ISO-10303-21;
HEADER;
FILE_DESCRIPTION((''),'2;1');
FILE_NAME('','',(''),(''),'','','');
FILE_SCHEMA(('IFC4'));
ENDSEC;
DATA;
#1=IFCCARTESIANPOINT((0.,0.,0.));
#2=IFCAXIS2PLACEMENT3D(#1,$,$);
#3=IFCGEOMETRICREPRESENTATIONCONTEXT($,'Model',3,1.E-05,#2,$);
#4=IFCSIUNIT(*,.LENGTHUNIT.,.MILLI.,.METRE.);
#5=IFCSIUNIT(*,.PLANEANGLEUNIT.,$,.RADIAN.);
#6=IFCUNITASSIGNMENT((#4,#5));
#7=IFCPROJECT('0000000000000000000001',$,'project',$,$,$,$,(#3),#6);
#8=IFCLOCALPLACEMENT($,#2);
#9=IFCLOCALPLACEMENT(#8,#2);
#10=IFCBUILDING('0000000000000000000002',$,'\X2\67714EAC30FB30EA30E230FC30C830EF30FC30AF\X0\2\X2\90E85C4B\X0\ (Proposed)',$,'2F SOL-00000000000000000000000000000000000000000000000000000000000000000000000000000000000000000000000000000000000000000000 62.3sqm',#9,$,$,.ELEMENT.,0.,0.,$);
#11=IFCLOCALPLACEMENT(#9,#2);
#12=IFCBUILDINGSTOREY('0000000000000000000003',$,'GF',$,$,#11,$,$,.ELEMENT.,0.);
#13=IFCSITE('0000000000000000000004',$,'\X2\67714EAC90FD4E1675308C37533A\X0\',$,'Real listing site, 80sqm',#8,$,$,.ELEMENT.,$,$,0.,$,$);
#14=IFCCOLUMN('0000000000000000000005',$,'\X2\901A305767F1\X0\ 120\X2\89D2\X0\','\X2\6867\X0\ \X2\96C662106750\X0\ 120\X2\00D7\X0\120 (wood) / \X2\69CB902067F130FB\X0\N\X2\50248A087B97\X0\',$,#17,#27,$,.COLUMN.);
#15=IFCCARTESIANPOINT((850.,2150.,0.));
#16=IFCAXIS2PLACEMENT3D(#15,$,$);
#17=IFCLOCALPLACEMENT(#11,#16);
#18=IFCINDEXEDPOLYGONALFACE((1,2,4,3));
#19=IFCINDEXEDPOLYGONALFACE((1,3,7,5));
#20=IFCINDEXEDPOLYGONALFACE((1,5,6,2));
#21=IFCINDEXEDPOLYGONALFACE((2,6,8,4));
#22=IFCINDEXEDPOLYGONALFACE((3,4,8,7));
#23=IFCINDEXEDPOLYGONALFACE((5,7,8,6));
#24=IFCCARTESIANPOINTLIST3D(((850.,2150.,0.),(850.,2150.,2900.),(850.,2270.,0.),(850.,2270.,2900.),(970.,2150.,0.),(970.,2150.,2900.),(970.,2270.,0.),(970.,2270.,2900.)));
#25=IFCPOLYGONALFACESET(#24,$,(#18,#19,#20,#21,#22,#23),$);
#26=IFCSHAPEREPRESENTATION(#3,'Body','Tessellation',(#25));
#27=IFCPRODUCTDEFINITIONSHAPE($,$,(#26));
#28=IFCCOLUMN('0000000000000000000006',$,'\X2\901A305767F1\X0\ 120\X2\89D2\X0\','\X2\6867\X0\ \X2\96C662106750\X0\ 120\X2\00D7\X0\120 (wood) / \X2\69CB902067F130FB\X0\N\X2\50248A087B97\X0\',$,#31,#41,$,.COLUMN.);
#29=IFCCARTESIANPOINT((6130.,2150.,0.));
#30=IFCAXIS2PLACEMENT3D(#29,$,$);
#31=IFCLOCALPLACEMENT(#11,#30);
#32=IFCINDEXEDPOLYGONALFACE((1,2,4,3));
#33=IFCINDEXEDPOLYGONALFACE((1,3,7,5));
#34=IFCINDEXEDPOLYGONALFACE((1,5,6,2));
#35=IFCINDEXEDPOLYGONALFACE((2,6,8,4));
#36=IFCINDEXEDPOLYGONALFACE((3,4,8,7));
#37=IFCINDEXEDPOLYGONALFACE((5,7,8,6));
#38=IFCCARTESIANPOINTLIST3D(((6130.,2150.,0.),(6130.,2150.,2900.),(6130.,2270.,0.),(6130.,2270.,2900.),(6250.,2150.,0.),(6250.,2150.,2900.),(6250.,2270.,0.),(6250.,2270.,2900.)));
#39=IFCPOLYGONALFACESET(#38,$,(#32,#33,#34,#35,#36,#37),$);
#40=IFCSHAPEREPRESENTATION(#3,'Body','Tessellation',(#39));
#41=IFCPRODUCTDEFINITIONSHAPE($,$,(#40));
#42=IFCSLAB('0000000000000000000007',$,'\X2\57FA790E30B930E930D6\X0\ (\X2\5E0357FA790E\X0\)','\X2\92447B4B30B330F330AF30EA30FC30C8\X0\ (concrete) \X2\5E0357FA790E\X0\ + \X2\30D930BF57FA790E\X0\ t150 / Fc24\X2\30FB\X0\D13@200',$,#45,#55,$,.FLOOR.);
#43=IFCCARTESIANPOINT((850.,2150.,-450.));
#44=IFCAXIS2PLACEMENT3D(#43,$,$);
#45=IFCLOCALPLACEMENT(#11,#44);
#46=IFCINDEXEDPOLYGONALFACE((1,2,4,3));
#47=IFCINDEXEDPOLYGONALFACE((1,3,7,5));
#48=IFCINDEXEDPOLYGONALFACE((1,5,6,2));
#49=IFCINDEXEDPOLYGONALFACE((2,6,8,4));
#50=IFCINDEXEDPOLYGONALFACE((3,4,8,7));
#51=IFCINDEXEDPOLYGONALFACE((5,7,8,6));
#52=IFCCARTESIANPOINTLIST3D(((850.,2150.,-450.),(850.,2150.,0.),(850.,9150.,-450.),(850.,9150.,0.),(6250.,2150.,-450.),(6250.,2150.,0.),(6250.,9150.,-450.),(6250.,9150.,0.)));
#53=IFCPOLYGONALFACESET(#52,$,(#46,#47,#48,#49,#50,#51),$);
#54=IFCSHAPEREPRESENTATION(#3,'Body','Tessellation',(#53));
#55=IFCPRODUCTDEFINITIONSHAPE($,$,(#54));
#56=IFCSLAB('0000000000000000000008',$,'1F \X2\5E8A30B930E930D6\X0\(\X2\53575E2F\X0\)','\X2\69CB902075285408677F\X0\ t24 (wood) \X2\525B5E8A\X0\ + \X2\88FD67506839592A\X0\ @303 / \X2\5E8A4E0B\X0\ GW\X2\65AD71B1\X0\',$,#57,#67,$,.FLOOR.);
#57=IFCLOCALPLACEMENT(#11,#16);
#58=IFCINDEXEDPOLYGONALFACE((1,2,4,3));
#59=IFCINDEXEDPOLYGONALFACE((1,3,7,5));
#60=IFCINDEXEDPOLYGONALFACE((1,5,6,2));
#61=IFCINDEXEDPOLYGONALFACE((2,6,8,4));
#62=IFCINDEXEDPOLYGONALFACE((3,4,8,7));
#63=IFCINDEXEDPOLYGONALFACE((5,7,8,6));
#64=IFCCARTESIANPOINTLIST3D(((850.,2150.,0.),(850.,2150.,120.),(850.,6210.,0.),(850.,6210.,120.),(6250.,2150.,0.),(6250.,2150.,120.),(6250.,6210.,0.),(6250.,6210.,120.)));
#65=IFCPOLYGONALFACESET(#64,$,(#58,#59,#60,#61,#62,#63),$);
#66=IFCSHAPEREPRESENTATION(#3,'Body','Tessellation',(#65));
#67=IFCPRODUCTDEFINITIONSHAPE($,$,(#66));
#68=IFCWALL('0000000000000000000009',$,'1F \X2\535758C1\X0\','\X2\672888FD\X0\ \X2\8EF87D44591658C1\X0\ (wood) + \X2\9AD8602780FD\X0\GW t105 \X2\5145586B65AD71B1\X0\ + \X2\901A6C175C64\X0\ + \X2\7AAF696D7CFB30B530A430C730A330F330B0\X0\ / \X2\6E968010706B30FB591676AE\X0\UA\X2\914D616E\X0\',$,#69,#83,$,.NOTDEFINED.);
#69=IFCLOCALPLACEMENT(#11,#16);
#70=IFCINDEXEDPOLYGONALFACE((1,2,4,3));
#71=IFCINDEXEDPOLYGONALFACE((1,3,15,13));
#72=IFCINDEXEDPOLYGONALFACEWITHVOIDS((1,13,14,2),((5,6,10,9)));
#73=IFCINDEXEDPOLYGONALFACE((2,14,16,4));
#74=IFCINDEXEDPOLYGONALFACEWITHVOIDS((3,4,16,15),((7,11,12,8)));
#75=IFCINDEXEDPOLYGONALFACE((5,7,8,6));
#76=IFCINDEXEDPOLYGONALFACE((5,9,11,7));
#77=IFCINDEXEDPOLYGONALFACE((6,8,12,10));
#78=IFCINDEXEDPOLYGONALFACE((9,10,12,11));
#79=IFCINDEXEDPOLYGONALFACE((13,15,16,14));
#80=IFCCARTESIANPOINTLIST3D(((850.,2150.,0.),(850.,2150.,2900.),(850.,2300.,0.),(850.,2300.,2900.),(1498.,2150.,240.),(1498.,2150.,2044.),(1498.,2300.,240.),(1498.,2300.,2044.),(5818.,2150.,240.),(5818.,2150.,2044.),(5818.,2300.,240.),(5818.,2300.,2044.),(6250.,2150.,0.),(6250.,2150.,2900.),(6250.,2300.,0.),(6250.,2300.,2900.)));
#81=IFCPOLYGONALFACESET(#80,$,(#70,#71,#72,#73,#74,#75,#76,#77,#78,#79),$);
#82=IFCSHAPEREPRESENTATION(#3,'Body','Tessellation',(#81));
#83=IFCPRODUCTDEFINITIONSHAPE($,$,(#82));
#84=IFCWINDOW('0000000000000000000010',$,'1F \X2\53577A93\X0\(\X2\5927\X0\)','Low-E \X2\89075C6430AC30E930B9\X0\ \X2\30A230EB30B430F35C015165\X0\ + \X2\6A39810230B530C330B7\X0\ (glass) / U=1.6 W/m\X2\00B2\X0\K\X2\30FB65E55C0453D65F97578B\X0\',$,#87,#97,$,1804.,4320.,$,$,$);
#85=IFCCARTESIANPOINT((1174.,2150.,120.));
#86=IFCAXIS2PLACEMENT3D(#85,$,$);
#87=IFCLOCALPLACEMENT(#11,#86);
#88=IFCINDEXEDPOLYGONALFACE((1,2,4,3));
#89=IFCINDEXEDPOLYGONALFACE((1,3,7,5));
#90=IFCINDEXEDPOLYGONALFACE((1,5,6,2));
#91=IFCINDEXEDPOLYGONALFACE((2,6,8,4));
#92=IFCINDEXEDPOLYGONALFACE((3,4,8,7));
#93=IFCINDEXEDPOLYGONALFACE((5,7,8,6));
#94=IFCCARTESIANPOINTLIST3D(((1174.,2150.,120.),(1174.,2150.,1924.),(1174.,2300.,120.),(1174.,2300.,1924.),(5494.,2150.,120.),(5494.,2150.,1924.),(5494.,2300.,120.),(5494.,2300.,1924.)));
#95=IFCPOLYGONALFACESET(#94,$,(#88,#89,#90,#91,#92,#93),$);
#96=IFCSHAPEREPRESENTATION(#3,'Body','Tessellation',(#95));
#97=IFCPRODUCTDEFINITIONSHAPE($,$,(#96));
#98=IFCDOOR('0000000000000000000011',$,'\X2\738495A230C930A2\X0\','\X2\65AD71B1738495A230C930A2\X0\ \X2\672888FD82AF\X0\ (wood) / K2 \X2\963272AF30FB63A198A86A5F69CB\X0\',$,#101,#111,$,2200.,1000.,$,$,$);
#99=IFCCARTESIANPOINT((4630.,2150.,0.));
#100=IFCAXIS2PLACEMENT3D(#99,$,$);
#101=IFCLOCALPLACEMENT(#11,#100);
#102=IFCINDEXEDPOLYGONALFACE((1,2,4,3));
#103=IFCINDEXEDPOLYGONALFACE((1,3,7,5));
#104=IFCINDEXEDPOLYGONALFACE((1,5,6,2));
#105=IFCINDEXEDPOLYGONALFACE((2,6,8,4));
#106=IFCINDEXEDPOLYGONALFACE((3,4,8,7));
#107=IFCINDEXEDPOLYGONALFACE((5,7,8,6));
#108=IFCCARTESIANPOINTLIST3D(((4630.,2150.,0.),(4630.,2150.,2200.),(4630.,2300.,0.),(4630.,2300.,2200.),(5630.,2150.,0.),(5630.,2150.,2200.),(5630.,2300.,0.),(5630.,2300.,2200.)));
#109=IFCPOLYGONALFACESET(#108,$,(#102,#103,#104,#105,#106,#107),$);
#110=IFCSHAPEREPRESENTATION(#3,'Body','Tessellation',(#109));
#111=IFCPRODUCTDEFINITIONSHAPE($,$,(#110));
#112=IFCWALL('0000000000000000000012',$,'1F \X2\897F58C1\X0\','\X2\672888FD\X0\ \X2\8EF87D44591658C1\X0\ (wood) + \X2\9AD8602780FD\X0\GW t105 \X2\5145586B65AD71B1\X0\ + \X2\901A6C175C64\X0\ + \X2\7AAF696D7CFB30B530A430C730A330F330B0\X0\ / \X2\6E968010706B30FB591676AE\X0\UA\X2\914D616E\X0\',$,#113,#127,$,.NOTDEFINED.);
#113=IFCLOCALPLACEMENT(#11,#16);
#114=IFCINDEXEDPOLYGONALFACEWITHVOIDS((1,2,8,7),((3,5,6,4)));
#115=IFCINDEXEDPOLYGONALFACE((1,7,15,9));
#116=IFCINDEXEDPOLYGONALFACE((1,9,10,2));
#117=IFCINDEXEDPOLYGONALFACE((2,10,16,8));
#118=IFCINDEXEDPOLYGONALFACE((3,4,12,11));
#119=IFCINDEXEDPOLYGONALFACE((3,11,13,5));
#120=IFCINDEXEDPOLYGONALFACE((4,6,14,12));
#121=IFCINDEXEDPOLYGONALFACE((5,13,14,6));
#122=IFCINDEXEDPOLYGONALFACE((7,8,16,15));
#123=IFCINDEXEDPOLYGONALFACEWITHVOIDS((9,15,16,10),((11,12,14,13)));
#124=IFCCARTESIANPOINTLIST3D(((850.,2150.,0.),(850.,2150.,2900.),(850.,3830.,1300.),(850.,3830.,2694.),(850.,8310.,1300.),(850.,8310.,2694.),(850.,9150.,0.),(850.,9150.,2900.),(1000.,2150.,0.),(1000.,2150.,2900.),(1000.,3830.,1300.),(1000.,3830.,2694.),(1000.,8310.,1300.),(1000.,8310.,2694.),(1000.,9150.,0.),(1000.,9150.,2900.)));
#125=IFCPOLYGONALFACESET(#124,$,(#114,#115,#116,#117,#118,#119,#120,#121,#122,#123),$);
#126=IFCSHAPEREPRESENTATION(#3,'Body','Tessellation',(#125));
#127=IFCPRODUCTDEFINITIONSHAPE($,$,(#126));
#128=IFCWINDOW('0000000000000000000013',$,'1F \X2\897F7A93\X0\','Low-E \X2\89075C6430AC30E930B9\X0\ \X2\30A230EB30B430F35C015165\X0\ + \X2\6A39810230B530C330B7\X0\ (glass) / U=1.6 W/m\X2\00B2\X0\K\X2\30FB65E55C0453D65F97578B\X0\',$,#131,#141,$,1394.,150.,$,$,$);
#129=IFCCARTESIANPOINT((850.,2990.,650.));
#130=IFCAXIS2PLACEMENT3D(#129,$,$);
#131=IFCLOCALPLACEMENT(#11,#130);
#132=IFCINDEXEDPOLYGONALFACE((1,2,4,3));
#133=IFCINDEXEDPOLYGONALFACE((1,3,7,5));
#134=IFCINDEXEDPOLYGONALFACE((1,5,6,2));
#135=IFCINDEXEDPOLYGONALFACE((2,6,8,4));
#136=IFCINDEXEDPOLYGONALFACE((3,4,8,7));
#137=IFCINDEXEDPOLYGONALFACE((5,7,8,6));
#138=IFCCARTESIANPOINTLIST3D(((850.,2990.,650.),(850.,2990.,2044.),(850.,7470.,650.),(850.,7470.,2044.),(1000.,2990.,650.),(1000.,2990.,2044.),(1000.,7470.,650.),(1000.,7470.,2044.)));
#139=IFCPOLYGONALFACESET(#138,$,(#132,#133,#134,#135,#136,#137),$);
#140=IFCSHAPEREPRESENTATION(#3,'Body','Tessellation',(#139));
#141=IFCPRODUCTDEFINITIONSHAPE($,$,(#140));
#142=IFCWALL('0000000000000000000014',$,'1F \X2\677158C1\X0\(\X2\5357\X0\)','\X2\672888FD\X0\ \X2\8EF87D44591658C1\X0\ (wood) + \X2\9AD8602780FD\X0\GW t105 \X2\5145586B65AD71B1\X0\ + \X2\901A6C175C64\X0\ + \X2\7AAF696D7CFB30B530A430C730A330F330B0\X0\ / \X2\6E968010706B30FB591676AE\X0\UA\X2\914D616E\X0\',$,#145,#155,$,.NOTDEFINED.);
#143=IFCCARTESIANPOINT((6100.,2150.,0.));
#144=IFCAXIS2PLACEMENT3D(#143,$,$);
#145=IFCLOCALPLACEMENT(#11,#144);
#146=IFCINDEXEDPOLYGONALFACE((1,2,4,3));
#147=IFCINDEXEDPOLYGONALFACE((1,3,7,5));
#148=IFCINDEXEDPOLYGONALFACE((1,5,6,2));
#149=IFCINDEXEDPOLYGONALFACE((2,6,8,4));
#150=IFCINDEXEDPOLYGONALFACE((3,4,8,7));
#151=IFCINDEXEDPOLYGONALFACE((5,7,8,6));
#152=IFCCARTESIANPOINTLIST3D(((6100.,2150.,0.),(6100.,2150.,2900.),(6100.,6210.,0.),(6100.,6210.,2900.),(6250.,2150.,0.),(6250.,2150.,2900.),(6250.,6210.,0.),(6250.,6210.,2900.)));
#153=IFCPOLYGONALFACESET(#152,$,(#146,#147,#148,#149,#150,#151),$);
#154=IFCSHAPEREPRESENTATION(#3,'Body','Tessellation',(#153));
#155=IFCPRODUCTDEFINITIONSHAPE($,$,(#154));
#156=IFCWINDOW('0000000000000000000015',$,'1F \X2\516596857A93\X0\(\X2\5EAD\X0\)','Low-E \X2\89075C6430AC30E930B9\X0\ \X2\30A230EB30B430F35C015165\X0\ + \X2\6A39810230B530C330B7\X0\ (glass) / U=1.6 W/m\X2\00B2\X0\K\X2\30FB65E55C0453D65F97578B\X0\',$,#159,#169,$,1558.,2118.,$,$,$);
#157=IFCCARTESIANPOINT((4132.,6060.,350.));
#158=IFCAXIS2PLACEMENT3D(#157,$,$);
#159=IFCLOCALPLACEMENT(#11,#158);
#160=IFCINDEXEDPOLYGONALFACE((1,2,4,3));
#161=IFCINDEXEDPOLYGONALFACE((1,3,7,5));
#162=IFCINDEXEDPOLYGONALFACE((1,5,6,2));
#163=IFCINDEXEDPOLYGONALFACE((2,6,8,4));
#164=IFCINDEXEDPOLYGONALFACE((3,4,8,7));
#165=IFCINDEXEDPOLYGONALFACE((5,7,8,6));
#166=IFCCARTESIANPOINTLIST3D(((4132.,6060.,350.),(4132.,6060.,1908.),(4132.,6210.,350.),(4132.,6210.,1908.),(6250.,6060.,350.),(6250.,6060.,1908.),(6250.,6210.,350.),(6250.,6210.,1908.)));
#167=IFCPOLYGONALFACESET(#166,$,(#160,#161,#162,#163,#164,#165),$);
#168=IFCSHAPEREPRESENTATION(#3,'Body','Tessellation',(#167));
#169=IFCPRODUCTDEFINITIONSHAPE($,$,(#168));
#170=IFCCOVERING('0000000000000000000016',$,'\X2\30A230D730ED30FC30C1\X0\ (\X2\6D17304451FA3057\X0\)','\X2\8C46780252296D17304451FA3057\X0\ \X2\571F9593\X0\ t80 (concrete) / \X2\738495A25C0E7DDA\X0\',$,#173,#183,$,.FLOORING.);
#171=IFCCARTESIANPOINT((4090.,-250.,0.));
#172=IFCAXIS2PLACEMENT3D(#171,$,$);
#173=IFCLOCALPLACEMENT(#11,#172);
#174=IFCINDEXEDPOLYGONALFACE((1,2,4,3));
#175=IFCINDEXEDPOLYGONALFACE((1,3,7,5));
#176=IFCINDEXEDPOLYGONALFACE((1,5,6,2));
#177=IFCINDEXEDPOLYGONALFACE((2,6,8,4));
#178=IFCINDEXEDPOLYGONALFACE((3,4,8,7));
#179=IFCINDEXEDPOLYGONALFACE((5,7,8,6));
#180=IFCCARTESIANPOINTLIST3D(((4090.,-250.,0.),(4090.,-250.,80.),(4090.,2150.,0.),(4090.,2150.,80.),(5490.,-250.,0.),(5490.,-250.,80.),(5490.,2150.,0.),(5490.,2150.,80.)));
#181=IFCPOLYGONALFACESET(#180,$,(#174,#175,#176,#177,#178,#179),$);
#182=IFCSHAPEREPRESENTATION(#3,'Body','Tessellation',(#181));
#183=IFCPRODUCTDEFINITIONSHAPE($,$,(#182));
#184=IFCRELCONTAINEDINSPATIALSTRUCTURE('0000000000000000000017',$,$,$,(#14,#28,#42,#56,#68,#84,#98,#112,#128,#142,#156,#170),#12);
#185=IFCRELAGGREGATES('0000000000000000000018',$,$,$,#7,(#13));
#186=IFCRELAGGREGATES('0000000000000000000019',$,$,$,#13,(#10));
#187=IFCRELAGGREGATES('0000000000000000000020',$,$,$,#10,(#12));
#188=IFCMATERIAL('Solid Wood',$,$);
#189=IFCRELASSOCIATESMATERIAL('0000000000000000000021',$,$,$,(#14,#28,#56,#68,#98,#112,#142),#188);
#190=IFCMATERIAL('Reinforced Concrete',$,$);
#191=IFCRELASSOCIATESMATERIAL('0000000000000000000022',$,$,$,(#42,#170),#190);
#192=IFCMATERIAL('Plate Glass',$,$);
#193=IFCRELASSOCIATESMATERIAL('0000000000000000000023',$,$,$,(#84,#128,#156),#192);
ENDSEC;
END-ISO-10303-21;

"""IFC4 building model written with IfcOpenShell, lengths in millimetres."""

from ifc_helpers import new_model, si_unit, frame, frame_2d, origin, place, context, project, spatial, rectangle, extrude, material, element, fill, save


model = new_model("IFC4")

# Units and contexts
model_context = context("Model", 3, precision=1e-05, world=origin())
ifc_project = project(units=[si_unit("LENGTHUNIT", "METRE", prefix="MILLI"), si_unit("PLANEANGLEUNIT", "RADIAN")], contexts=[model_context])

# Site, building, storey
site_placement = place(None, origin())
site = spatial("IfcSite", under=ifc_project, at=site_placement, Name="東京都世田谷区", ObjectType="Real listing site, 80sqm", CompositionType="ELEMENT", RefElevation=0.0)
building_placement = place(site_placement, origin())
building = spatial("IfcBuilding", under=site, at=building_placement, Name="東京・リモートワーク2部屋 (Proposed)", ObjectType="2F SOL-00000000000000000000000000000000000000000000000000000000000000000000000000000000000000000000000000000000000000000000 62.3sqm", CompositionType="ELEMENT", ElevationOfRefHeight=0.0, ElevationOfTerrain=0.0)
storey_placement = place(building_placement, origin())
storey = spatial("IfcBuildingStorey", under=building, at=storey_placement, Name="GF", CompositionType="ELEMENT", Elevation=0.0)

# Columns
ifc_material_1 = material(Name="Solid Wood")
column_1_placement = place(storey_placement, frame((850.0, 2150.0, 0.0)))
element("IfcColumn", 1, at=column_1_placement, inside=storey, material=ifc_material_1, Name="通し柱 120角", Description="桧 集成材 120×120 (wood) / 構造柱・N値計算", PredefinedType="COLUMN", context=model_context, shape_type="SweptSolid", body=[
    extrude(rectangle(XDim=120.0, YDim=120.0, at=frame_2d((60.0, 60.0))), frame((850.0, 2150.0, 0.0)), (0.0, 0.0, 1.0), 2900.0),
])
column_2_placement = place(storey_placement, frame((6130.0, 2150.0, 0.0)))
element("IfcColumn", 2, at=column_2_placement, inside=storey, material=ifc_material_1, Name="通し柱 120角", Description="桧 集成材 120×120 (wood) / 構造柱・N値計算", PredefinedType="COLUMN", context=model_context, shape_type="SweptSolid", body=[
    extrude(rectangle(XDim=120.0, YDim=120.0, at=frame_2d((60.0, 60.0))), frame((6130.0, 2150.0, 0.0)), (0.0, 0.0, 1.0), 2900.0),
])

# Slabs
ifc_material_2 = material(Name="Reinforced Concrete")
slab_1_placement = place(storey_placement, frame((850.0, 2150.0, -450.0)))
element("IfcSlab", 3, at=slab_1_placement, inside=storey, material=ifc_material_2, Name="基礎スラブ (布基礎)", Description="鉄筋コンクリート (concrete) 布基礎 + ベタ基礎 t150 / Fc24・D13@200", PredefinedType="FLOOR", context=model_context, shape_type="SweptSolid", body=[
    extrude(rectangle(XDim=5400.0, YDim=7000.0, at=frame_2d((2700.0, 3500.0))), frame((850.0, 2150.0, -450.0)), (0.0, 0.0, 1.0), 450.0),
])
slab_2_placement = place(storey_placement, frame((850.0, 2150.0, 0.0)))
element("IfcSlab", 4, at=slab_2_placement, inside=storey, material=ifc_material_1, Name="1F 床スラブ(南帯)", Description="構造用合板 t24 (wood) 剛床 + 製材根太 @303 / 床下 GW断熱", PredefinedType="FLOOR", context=model_context, shape_type="SweptSolid", body=[
    extrude(rectangle(XDim=5400.0, YDim=4060.0, at=frame_2d((2700.0, 2030.0))), frame((850.0, 2150.0, 0.0)), (0.0, 0.0, 1.0), 120.0),
])

# Wall, openings, window, door
wall_1_placement = place(storey_placement, frame((850.0, 2150.0, 0.0)))
wall_1 = element("IfcWall", 5, at=wall_1_placement, inside=storey, material=ifc_material_1, Name="1F 南壁", Description="木製 軸組外壁 (wood) + 高性能GW t105 充填断熱 + 通気層 + 窯業系サイディング / 準耐火・外皮UA配慮", PredefinedType="NOTDEFINED", context=model_context, shape_type="SweptSolid", body=[
    extrude(rectangle(XDim=5400.0, YDim=150.0, at=frame_2d((2700.0, 75.0))), frame((850.0, 2150.0, 0.0)), (0.0, 0.0, 1.0), 2900.0),
])
opening_1_placement = place(storey_placement, frame((1174.0, 2150.0, 120.0)))
opening_1 = element("IfcOpeningElement", 6, at=opening_1_placement, cuts=wall_1, PredefinedType="NOTDEFINED", context=model_context, shape_type="SweptSolid", body=[
    extrude(rectangle(XDim=4320.0, YDim=150.0, at=frame_2d((2160.0, 75.0))), frame((1174.0, 2150.0, 120.0)), (0.0, 0.0, 1.0), 1804.0),
])
opening_2_placement = place(storey_placement, frame((4630.0, 2150.0, 0.0)))
opening_2 = element("IfcOpeningElement", 7, at=opening_2_placement, cuts=wall_1, PredefinedType="NOTDEFINED", context=model_context, shape_type="SweptSolid", body=[
    extrude(rectangle(XDim=1000.0, YDim=150.0, at=frame_2d((500.0, 75.0))), frame((4630.0, 2150.0, 0.0)), (0.0, 0.0, 1.0), 2200.0),
])
ifc_material_3 = material(Name="Plate Glass")
window_1_placement = place(storey_placement, frame((1174.0, 2150.0, 120.0)))
window_1 = element("IfcWindow", 8, at=window_1_placement, inside=storey, material=ifc_material_3, Name="1F 南窓(大)", Description="Low-E 複層ガラス アルゴン封入 + 樹脂サッシ (glass) / U=1.6 W/m²K・日射取得型", OverallHeight=1804.0, OverallWidth=4320.0, context=model_context, shape_type="SweptSolid", body=[
    extrude(rectangle(XDim=4320.0, YDim=150.0, at=frame_2d((2160.0, 75.0))), frame((1174.0, 2150.0, 120.0)), (0.0, 0.0, 1.0), 1804.0),
])
fill(opening_1, window_1)
door_1_placement = place(storey_placement, frame((4630.0, 2150.0, 0.0)))
door_1 = element("IfcDoor", 9, at=door_1_placement, inside=storey, material=ifc_material_1, Name="玄関ドア", Description="断熱玄関ドア 木製芯 (wood) / K2 防犯・採風機構", OverallHeight=2200.0, OverallWidth=1000.0, context=model_context, shape_type="SweptSolid", body=[
    extrude(rectangle(XDim=1000.0, YDim=150.0, at=frame_2d((500.0, 75.0))), frame((4630.0, 2150.0, 0.0)), (0.0, 0.0, 1.0), 2200.0),
])
fill(opening_2, door_1)

# Walls, openings, windows
wall_2_placement = place(storey_placement, frame((850.0, 2150.0, 0.0)))
wall_2 = element("IfcWall", 10, at=wall_2_placement, inside=storey, material=ifc_material_1, Name="1F 西壁", Description="木製 軸組外壁 (wood) + 高性能GW t105 充填断熱 + 通気層 + 窯業系サイディング / 準耐火・外皮UA配慮", PredefinedType="NOTDEFINED", context=model_context, shape_type="SweptSolid", body=[
    extrude(rectangle(XDim=150.0, YDim=7000.0, at=frame_2d((75.0, 3500.0))), frame((850.0, 2150.0, 0.0)), (0.0, 0.0, 1.0), 2900.0),
])
opening_3_placement = place(storey_placement, frame((850.0, 2990.0, 650.0)))
opening_3 = element("IfcOpeningElement", 11, at=opening_3_placement, cuts=wall_2, PredefinedType="NOTDEFINED", context=model_context, shape_type="SweptSolid", body=[
    extrude(rectangle(XDim=150.0, YDim=4480.0, at=frame_2d((75.0, 2240.0))), frame((850.0, 2990.0, 650.0)), (0.0, 0.0, 1.0), 1394.0),
])
window_2_placement = place(storey_placement, frame((850.0, 2990.0, 650.0)))
window_2 = element("IfcWindow", 12, at=window_2_placement, inside=storey, material=ifc_material_3, Name="1F 西窓", Description="Low-E 複層ガラス アルゴン封入 + 樹脂サッシ (glass) / U=1.6 W/m²K・日射取得型", OverallHeight=1394.0, OverallWidth=150.0, context=model_context, shape_type="SweptSolid", body=[
    extrude(rectangle(XDim=150.0, YDim=4480.0, at=frame_2d((75.0, 2240.0))), frame((850.0, 2990.0, 650.0)), (0.0, 0.0, 1.0), 1394.0),
])
fill(opening_3, window_2)
wall_3_placement = place(storey_placement, frame((6100.0, 2150.0, 0.0)))
wall_3 = element("IfcWall", 13, at=wall_3_placement, inside=storey, material=ifc_material_1, Name="1F 東壁(南)", Description="木製 軸組外壁 (wood) + 高性能GW t105 充填断熱 + 通気層 + 窯業系サイディング / 準耐火・外皮UA配慮", PredefinedType="NOTDEFINED", context=model_context, shape_type="SweptSolid", body=[
    extrude(rectangle(XDim=150.0, YDim=4060.0, at=frame_2d((75.0, 2030.0))), frame((6100.0, 2150.0, 0.0)), (0.0, 0.0, 1.0), 2900.0),
])
opening_4_placement = place(storey_placement, frame((4132.0, 6060.0, 350.0)))
opening_4 = element("IfcOpeningElement", 14, at=opening_4_placement, cuts=wall_3, PredefinedType="NOTDEFINED", context=model_context, shape_type="SweptSolid", body=[
    extrude(rectangle(XDim=2118.0, YDim=150.0, at=frame_2d((1059.0, 75.0))), frame((4132.0, 6060.0, 350.0)), (0.0, 0.0, 1.0), 1558.0),
])
window_3_placement = place(storey_placement, frame((4132.0, 6060.0, 350.0)))
window_3 = element("IfcWindow", 15, at=window_3_placement, inside=storey, material=ifc_material_3, Name="1F 入隅窓(庭)", Description="Low-E 複層ガラス アルゴン封入 + 樹脂サッシ (glass) / U=1.6 W/m²K・日射取得型", OverallHeight=1558.0, OverallWidth=2118.0, context=model_context, shape_type="SweptSolid", body=[
    extrude(rectangle(XDim=2118.0, YDim=150.0, at=frame_2d((1059.0, 75.0))), frame((4132.0, 6060.0, 350.0)), (0.0, 0.0, 1.0), 1558.0),
])
fill(opening_4, window_3)

# Covering
covering_1_placement = place(storey_placement, frame((4090.0, -250.0, 0.0)))
element("IfcCovering", 16, at=covering_1_placement, inside=storey, material=ifc_material_2, Name="アプローチ (洗い出し)", Description="豆砂利洗い出し 土間 t80 (concrete) / 玄関導線", PredefinedType="FLOORING", context=model_context, shape_type="SweptSolid", body=[
    extrude(rectangle(XDim=1400.0, YDim=2400.0, at=frame_2d((700.0, 1200.0))), frame((4090.0, -250.0, 0.0)), (0.0, 0.0, 1.0), 80.0),
])

save(model, "model.ifc")
